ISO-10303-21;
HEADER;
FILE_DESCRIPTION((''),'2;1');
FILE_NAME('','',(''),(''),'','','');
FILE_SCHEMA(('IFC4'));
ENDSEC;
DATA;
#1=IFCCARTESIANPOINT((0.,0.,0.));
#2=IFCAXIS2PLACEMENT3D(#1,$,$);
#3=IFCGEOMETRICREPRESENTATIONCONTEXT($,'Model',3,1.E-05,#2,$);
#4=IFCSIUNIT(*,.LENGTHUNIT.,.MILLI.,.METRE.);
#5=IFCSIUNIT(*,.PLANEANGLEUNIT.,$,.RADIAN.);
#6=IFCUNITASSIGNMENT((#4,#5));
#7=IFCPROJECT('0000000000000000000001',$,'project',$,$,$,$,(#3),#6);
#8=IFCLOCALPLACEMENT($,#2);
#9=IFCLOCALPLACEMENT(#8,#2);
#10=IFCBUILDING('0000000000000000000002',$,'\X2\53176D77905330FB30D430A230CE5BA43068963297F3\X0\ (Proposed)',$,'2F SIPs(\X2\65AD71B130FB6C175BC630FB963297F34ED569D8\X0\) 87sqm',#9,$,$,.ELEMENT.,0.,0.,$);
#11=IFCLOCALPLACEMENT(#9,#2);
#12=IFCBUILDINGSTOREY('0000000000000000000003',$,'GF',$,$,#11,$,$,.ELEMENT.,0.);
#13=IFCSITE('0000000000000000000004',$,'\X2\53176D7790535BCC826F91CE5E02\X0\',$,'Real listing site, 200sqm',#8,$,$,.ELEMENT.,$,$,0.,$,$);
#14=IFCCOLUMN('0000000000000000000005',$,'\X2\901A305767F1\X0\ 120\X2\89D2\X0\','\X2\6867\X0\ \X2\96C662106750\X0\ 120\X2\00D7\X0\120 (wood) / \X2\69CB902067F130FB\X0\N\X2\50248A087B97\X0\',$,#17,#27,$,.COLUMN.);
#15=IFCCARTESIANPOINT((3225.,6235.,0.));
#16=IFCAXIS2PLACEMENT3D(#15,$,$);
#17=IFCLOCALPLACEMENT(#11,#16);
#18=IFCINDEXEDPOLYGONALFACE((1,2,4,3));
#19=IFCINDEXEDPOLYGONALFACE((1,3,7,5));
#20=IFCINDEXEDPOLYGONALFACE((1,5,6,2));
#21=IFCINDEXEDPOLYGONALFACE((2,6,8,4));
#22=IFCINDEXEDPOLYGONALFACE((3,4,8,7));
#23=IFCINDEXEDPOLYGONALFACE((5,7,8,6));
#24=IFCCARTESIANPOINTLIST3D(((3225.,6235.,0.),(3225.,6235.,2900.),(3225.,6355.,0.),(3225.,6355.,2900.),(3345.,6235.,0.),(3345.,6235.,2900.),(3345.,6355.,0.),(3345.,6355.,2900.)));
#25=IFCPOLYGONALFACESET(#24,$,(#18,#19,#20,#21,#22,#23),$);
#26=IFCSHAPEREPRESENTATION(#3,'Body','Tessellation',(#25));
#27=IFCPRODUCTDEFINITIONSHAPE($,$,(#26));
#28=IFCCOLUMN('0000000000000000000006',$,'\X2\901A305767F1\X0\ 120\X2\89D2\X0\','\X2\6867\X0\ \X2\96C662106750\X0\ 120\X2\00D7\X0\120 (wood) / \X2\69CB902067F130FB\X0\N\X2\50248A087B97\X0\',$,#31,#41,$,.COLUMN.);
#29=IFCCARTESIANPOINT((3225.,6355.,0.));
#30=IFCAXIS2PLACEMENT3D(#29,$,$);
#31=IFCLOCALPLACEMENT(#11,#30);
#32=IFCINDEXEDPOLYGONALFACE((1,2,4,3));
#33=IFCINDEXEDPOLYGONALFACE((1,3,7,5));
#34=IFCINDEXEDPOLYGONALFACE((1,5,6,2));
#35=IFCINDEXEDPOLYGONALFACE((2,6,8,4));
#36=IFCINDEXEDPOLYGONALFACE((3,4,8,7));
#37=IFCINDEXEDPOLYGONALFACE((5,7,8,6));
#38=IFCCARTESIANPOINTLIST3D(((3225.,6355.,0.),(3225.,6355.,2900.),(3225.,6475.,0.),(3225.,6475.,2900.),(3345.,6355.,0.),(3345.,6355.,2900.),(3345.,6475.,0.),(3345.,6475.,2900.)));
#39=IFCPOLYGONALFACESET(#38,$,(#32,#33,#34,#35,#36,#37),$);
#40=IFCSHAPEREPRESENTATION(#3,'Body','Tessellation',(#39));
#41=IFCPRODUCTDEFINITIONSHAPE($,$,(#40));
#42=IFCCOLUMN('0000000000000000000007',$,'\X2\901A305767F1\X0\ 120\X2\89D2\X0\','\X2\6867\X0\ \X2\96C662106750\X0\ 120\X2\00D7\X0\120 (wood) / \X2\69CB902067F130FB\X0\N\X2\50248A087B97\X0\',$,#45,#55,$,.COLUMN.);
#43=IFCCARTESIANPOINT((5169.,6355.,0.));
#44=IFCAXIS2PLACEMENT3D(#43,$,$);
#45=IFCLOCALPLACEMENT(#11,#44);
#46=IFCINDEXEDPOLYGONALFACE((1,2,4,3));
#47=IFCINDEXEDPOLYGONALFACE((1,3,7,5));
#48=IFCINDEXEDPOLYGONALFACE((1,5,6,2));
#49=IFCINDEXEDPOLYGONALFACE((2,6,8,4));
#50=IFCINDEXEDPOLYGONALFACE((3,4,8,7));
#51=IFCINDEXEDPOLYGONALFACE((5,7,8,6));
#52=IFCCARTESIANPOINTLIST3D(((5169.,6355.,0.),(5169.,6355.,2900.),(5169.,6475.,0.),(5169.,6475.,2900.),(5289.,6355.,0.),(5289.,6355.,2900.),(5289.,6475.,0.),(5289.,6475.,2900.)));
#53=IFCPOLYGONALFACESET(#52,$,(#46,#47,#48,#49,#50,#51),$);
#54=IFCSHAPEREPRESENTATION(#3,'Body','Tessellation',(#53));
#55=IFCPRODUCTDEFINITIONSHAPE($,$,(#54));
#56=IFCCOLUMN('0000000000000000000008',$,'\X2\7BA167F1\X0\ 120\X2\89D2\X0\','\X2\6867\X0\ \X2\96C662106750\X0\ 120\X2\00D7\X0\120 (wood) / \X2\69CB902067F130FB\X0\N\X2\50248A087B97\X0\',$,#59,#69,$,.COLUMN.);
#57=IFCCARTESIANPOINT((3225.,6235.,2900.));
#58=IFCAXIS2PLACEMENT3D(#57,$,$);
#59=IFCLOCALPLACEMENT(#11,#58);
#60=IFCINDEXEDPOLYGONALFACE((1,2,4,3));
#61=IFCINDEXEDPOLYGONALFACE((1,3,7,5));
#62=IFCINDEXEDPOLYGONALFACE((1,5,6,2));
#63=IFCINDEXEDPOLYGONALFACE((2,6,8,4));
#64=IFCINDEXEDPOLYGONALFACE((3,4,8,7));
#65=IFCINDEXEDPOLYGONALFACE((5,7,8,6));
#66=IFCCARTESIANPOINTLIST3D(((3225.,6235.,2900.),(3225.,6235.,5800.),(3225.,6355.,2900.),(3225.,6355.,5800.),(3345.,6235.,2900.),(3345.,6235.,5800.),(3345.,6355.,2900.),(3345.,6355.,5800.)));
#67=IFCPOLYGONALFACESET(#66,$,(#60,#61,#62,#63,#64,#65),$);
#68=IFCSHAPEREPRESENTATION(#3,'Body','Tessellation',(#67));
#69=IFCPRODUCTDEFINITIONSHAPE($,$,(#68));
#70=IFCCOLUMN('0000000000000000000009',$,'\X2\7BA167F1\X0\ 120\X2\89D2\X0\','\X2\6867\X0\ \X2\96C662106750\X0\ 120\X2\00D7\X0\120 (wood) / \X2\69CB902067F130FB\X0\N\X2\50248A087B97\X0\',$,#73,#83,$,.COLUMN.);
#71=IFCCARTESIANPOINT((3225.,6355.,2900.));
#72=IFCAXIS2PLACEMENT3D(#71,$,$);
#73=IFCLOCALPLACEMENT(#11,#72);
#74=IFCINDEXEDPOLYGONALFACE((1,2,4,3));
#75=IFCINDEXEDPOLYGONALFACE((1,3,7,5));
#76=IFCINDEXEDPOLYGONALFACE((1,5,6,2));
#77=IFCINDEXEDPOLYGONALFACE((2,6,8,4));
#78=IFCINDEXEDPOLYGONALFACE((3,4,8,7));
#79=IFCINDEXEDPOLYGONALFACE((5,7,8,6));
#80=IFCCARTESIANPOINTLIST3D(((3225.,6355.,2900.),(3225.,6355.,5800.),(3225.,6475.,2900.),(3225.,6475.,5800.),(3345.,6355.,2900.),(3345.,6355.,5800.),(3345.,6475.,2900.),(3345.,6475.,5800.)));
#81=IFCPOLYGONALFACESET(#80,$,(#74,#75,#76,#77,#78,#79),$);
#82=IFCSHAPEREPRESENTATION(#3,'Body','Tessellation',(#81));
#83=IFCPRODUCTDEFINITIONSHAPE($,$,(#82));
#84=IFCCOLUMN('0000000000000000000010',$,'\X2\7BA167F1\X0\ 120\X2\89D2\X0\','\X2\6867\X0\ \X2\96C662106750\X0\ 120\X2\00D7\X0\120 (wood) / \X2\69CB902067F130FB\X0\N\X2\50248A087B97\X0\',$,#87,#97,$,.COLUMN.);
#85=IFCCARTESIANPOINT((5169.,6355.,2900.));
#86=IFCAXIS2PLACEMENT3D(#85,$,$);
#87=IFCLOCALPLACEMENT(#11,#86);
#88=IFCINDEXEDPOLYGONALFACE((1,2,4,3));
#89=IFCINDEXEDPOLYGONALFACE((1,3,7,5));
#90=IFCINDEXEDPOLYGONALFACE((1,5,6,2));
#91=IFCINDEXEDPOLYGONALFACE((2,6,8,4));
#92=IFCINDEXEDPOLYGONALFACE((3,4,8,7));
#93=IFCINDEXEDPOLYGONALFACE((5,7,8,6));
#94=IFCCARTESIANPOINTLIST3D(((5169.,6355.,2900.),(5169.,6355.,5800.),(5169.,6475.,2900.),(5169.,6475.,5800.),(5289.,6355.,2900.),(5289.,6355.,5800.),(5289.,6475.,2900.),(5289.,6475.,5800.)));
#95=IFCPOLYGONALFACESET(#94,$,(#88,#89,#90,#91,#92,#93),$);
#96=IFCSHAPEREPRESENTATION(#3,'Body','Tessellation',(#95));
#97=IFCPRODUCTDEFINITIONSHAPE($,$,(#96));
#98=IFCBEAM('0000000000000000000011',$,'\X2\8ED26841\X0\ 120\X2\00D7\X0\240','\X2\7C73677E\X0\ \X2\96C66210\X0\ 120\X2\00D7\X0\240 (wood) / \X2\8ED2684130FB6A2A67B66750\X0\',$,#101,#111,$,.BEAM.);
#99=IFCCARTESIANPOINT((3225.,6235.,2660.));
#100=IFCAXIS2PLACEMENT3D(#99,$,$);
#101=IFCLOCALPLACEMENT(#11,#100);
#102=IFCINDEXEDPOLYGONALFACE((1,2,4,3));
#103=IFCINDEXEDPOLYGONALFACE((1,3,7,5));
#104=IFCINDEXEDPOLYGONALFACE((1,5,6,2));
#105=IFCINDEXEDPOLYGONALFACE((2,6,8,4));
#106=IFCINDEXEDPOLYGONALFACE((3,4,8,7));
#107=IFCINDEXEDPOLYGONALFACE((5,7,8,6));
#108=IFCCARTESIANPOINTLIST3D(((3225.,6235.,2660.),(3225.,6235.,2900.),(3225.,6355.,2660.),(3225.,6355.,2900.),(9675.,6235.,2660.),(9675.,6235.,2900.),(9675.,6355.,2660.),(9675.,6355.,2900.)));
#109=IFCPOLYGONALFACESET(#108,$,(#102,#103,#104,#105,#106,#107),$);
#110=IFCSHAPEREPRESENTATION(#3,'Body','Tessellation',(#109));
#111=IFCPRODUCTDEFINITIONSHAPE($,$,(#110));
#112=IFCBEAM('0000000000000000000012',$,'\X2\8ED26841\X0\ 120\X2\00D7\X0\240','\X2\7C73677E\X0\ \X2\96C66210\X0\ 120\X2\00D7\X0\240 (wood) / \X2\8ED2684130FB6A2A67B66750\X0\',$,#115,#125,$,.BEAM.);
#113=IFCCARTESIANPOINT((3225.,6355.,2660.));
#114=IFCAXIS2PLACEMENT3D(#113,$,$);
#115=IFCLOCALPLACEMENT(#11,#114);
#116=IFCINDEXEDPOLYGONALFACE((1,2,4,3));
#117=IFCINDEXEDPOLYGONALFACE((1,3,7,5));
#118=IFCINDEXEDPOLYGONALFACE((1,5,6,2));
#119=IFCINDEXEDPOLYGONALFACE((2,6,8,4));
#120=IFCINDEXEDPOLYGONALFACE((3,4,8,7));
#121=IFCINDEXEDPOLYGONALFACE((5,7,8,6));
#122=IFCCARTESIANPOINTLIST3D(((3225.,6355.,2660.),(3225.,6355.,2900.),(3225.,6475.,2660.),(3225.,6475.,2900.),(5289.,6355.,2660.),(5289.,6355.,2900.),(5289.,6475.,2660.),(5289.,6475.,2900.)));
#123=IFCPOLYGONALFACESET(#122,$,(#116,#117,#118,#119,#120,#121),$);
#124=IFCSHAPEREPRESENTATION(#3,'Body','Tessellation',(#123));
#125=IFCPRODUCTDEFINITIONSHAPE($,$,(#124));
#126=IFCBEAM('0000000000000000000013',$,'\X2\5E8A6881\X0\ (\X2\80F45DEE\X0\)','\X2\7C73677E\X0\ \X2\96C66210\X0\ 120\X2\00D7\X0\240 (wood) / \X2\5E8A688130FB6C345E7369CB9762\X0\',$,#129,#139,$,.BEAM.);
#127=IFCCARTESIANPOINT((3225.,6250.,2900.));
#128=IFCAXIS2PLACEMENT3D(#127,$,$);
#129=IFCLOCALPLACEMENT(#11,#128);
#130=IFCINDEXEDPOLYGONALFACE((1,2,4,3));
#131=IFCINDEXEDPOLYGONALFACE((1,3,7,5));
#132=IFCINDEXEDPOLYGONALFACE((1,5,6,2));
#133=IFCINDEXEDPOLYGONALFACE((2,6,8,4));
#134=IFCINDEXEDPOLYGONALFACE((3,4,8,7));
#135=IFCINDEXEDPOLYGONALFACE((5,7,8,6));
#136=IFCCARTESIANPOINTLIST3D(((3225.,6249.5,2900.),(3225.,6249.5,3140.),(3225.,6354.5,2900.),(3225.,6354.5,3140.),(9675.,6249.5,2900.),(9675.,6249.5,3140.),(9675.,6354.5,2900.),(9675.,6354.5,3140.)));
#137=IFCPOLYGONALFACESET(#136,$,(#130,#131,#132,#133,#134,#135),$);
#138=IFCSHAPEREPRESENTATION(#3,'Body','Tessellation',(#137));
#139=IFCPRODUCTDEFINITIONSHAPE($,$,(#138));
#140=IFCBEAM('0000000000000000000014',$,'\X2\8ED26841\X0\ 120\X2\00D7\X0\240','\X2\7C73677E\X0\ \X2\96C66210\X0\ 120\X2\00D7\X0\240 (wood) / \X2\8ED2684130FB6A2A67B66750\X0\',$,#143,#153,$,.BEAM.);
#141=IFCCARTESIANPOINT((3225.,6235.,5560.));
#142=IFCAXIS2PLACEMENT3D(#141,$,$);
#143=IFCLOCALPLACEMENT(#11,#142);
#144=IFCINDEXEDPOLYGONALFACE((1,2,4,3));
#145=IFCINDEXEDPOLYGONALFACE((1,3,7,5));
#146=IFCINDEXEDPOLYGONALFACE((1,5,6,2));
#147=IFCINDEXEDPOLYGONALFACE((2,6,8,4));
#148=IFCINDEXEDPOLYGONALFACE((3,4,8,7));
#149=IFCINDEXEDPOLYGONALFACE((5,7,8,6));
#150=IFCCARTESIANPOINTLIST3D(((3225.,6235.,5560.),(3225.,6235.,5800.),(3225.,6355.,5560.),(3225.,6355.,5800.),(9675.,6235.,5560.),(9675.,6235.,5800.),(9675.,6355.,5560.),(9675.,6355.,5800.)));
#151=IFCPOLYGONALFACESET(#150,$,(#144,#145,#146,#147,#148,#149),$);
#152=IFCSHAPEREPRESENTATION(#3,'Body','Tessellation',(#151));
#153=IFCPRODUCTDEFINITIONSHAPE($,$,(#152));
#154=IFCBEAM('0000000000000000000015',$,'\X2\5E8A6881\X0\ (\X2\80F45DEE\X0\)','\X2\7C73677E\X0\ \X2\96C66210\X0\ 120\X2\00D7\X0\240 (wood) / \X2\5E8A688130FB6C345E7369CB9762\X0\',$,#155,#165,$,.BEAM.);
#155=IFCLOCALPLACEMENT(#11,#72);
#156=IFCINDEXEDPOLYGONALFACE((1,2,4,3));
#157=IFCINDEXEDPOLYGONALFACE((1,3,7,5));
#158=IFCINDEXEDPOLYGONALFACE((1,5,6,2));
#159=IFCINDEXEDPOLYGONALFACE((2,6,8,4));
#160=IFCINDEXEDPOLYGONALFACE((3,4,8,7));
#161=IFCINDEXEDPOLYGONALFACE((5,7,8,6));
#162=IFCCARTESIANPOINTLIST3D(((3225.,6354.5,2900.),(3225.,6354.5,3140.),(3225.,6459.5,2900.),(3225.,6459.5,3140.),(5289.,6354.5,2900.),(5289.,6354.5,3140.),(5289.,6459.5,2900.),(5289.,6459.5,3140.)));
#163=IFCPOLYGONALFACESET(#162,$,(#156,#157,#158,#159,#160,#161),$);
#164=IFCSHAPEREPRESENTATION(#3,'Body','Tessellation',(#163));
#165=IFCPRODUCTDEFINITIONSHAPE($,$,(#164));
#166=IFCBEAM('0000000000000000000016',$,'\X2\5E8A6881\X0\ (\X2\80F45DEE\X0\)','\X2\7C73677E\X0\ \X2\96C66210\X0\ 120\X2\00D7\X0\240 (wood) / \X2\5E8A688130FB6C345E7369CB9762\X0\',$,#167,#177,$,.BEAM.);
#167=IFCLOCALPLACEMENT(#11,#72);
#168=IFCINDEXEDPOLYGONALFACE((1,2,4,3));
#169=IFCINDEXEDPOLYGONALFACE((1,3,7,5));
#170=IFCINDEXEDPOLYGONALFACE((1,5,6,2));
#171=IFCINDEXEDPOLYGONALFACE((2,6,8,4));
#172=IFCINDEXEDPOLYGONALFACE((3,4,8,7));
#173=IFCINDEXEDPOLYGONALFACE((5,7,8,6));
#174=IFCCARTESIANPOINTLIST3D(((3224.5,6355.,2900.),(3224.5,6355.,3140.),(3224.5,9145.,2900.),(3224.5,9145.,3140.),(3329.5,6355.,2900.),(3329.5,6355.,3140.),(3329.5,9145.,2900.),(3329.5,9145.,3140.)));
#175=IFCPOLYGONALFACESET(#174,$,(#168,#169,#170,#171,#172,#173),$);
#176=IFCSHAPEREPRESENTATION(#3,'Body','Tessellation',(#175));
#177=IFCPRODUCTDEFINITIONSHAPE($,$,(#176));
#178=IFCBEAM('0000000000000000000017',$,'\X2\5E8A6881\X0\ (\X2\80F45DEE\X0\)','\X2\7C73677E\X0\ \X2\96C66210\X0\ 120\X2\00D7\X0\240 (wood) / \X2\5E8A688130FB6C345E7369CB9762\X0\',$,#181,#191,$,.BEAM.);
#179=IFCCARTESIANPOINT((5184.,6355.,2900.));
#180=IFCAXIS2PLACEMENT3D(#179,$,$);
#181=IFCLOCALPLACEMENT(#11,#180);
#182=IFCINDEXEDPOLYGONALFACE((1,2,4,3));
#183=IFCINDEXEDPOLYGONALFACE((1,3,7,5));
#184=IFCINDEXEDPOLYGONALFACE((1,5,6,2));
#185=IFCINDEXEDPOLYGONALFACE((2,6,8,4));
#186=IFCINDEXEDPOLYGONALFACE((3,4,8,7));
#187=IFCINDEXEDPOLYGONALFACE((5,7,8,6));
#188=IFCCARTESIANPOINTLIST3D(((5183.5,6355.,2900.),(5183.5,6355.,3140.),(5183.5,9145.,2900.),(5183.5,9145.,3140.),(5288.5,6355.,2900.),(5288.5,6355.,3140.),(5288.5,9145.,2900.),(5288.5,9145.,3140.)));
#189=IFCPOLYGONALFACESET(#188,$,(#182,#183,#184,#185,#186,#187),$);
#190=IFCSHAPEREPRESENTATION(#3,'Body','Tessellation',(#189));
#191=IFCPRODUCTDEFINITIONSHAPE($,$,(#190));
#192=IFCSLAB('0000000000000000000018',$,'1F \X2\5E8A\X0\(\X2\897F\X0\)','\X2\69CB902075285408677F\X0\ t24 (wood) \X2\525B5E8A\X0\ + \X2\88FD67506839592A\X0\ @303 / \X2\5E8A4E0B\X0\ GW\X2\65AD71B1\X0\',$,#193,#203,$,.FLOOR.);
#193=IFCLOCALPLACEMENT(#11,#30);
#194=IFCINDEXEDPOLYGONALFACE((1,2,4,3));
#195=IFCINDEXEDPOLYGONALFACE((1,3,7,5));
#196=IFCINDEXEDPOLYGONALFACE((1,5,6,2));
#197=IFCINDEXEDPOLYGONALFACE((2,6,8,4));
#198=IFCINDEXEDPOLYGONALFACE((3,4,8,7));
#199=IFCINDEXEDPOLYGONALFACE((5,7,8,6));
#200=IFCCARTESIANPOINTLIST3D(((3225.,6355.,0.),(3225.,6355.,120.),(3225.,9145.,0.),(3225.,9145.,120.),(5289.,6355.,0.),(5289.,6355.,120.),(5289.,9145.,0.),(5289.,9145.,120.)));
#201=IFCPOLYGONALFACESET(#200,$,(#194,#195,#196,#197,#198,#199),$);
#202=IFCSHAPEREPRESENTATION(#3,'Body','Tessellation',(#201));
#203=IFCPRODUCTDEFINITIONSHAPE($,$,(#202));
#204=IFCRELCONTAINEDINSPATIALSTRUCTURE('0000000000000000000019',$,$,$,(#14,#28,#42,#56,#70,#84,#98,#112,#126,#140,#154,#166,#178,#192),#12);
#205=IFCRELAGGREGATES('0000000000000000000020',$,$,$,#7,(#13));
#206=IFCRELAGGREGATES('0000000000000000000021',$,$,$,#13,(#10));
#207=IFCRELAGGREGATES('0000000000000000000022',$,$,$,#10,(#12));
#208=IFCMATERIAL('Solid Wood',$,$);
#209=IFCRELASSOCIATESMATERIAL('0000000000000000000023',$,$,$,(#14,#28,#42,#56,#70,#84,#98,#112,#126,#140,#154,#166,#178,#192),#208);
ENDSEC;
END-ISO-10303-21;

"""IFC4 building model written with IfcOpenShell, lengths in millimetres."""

from ifc_helpers import new_model, si_unit, frame, frame_2d, origin, place, context, project, spatial, rectangle, extrude, material, element, save


model = new_model("IFC4")

# Units and contexts
model_context = context("Model", 3, precision=1e-05, world=origin())
ifc_project = project(units=[si_unit("LENGTHUNIT", "METRE", prefix="MILLI"), si_unit("PLANEANGLEUNIT", "RADIAN")], contexts=[model_context])

# Site, building, storey
site_placement = place(None, origin())
site = spatial("IfcSite", under=ifc_project, at=site_placement, Name="北海道富良野市", ObjectType="Real listing site, 200sqm", CompositionType="ELEMENT", RefElevation=0.0)
building_placement = place(site_placement, origin())
building = spatial("IfcBuilding", under=site, at=building_placement, Name="北海道・ピアノ室と防音 (Proposed)", ObjectType="2F SIPs(断熱・気密・防音仕様) 87sqm", CompositionType="ELEMENT", ElevationOfRefHeight=0.0, ElevationOfTerrain=0.0)
storey_placement = place(building_placement, origin())
storey = spatial("IfcBuildingStorey", under=building, at=storey_placement, Name="GF", CompositionType="ELEMENT", Elevation=0.0)

# Columns
ifc_material_1 = material(Name="Solid Wood")
column_1_placement = place(storey_placement, frame((3225.0, 6235.0, 0.0)))
element("IfcColumn", 1, at=column_1_placement, inside=storey, material=ifc_material_1, Name="通し柱 120角", Description="桧 集成材 120×120 (wood) / 構造柱・N値計算", PredefinedType="COLUMN", context=model_context, shape_type="SweptSolid", body=[
    extrude(rectangle(XDim=120.0, YDim=120.0, at=frame_2d((60.0, 60.0))), frame((3225.0, 6235.0, 0.0)), (0.0, 0.0, 1.0), 2900.0),
])
column_2_placement = place(storey_placement, frame((3225.0, 6355.0, 0.0)))
element("IfcColumn", 2, at=column_2_placement, inside=storey, material=ifc_material_1, Name="通し柱 120角", Description="桧 集成材 120×120 (wood) / 構造柱・N値計算", PredefinedType="COLUMN", context=model_context, shape_type="SweptSolid", body=[
    extrude(rectangle(XDim=120.0, YDim=120.0, at=frame_2d((60.0, 60.0))), frame((3225.0, 6355.0, 0.0)), (0.0, 0.0, 1.0), 2900.0),
])
column_3_placement = place(storey_placement, frame((5169.0, 6355.0, 0.0)))
element("IfcColumn", 3, at=column_3_placement, inside=storey, material=ifc_material_1, Name="通し柱 120角", Description="桧 集成材 120×120 (wood) / 構造柱・N値計算", PredefinedType="COLUMN", context=model_context, shape_type="SweptSolid", body=[
    extrude(rectangle(XDim=120.0, YDim=120.0, at=frame_2d((60.0, 60.0))), frame((5169.0, 6355.0, 0.0)), (0.0, 0.0, 1.0), 2900.0),
])
column_4_placement = place(storey_placement, frame((3225.0, 6235.0, 2900.0)))
element("IfcColumn", 4, at=column_4_placement, inside=storey, material=ifc_material_1, Name="管柱 120角", Description="桧 集成材 120×120 (wood) / 構造柱・N値計算", PredefinedType="COLUMN", context=model_context, shape_type="SweptSolid", body=[
    extrude(rectangle(XDim=120.0, YDim=120.0, at=frame_2d((60.0, 60.0))), frame((3225.0, 6235.0, 2900.0)), (0.0, 0.0, 1.0), 2900.0),
])
column_5_placement = place(storey_placement, frame((3225.0, 6355.0, 2900.0)))
element("IfcColumn", 5, at=column_5_placement, inside=storey, material=ifc_material_1, Name="管柱 120角", Description="桧 集成材 120×120 (wood) / 構造柱・N値計算", PredefinedType="COLUMN", context=model_context, shape_type="SweptSolid", body=[
    extrude(rectangle(XDim=120.0, YDim=120.0, at=frame_2d((60.0, 60.0))), frame((3225.0, 6355.0, 2900.0)), (0.0, 0.0, 1.0), 2900.0),
])
column_6_placement = place(storey_placement, frame((5169.0, 6355.0, 2900.0)))
element("IfcColumn", 6, at=column_6_placement, inside=storey, material=ifc_material_1, Name="管柱 120角", Description="桧 集成材 120×120 (wood) / 構造柱・N値計算", PredefinedType="COLUMN", context=model_context, shape_type="SweptSolid", body=[
    extrude(rectangle(XDim=120.0, YDim=120.0, at=frame_2d((60.0, 60.0))), frame((5169.0, 6355.0, 2900.0)), (0.0, 0.0, 1.0), 2900.0),
])

# Beams
beam_1_placement = place(storey_placement, frame((3225.0, 6235.0, 2660.0)))
element("IfcBeam", 7, at=beam_1_placement, inside=storey, material=ifc_material_1, Name="軒桁 120×240", Description="米松 集成 120×240 (wood) / 軒桁・横架材", PredefinedType="BEAM", context=model_context, shape_type="SweptSolid", body=[
    extrude(rectangle(XDim=6450.0, YDim=120.0, at=frame_2d((3225.0, 60.0))), frame((3225.0, 6235.0, 2660.0)), (0.0, 0.0, 1.0), 240.0),
])
beam_2_placement = place(storey_placement, frame((3225.0, 6355.0, 2660.0)))
element("IfcBeam", 8, at=beam_2_placement, inside=storey, material=ifc_material_1, Name="軒桁 120×240", Description="米松 集成 120×240 (wood) / 軒桁・横架材", PredefinedType="BEAM", context=model_context, shape_type="SweptSolid", body=[
    extrude(rectangle(XDim=2064.0, YDim=120.0, at=frame_2d((1032.0, 60.0))), frame((3225.0, 6355.0, 2660.0)), (0.0, 0.0, 1.0), 240.0),
])
beam_3_placement = place(storey_placement, frame((3225.0, 6250.0, 2900.0)))
element("IfcBeam", 9, at=beam_3_placement, inside=storey, material=ifc_material_1, Name="床梁 (胴差)", Description="米松 集成 120×240 (wood) / 床梁・水平構面", PredefinedType="BEAM", context=model_context, shape_type="SweptSolid", body=[
    extrude(rectangle(XDim=6450.0, YDim=105.0, at=frame_2d((3225.0, 52.0))), frame((3225.0, 6250.0, 2900.0)), (0.0, 0.0, 1.0), 240.0),
])
beam_4_placement = place(storey_placement, frame((3225.0, 6235.0, 5560.0)))
element("IfcBeam", 10, at=beam_4_placement, inside=storey, material=ifc_material_1, Name="軒桁 120×240", Description="米松 集成 120×240 (wood) / 軒桁・横架材", PredefinedType="BEAM", context=model_context, shape_type="SweptSolid", body=[
    extrude(rectangle(XDim=6450.0, YDim=120.0, at=frame_2d((3225.0, 60.0))), frame((3225.0, 6235.0, 5560.0)), (0.0, 0.0, 1.0), 240.0),
])
beam_5_placement = place(storey_placement, frame((3225.0, 6355.0, 2900.0)))
element("IfcBeam", 11, at=beam_5_placement, inside=storey, material=ifc_material_1, Name="床梁 (胴差)", Description="米松 集成 120×240 (wood) / 床梁・水平構面", PredefinedType="BEAM", context=model_context, shape_type="SweptSolid", body=[
    extrude(rectangle(XDim=2064.0, YDim=105.0, at=frame_2d((1032.0, 52.0))), frame((3225.0, 6355.0, 2900.0)), (0.0, 0.0, 1.0), 240.0),
])
beam_6_placement = place(storey_placement, frame((3225.0, 6355.0, 2900.0)))
element("IfcBeam", 12, at=beam_6_placement, inside=storey, material=ifc_material_1, Name="床梁 (胴差)", Description="米松 集成 120×240 (wood) / 床梁・水平構面", PredefinedType="BEAM", context=model_context, shape_type="SweptSolid", body=[
    extrude(rectangle(XDim=105.0, YDim=2790.0, at=frame_2d((52.0, 1395.0))), frame((3225.0, 6355.0, 2900.0)), (0.0, 0.0, 1.0), 240.0),
])
beam_7_placement = place(storey_placement, frame((5184.0, 6355.0, 2900.0)))
element("IfcBeam", 13, at=beam_7_placement, inside=storey, material=ifc_material_1, Name="床梁 (胴差)", Description="米松 集成 120×240 (wood) / 床梁・水平構面", PredefinedType="BEAM", context=model_context, shape_type="SweptSolid", body=[
    extrude(rectangle(XDim=105.0, YDim=2790.0, at=frame_2d((52.0, 1395.0))), frame((5184.0, 6355.0, 2900.0)), (0.0, 0.0, 1.0), 240.0),
])

# Slab
slab_1_placement = place(storey_placement, frame((3225.0, 6355.0, 0.0)))
element("IfcSlab", 14, at=slab_1_placement, inside=storey, material=ifc_material_1, Name="1F 床(西)", Description="構造用合板 t24 (wood) 剛床 + 製材根太 @303 / 床下 GW断熱", PredefinedType="FLOOR", context=model_context, shape_type="SweptSolid", body=[
    extrude(rectangle(XDim=2064.0, YDim=2790.0, at=frame_2d((1032.0, 1395.0))), frame((3225.0, 6355.0, 0.0)), (0.0, 0.0, 1.0), 120.0),
])

save(model, "model.ifc")
